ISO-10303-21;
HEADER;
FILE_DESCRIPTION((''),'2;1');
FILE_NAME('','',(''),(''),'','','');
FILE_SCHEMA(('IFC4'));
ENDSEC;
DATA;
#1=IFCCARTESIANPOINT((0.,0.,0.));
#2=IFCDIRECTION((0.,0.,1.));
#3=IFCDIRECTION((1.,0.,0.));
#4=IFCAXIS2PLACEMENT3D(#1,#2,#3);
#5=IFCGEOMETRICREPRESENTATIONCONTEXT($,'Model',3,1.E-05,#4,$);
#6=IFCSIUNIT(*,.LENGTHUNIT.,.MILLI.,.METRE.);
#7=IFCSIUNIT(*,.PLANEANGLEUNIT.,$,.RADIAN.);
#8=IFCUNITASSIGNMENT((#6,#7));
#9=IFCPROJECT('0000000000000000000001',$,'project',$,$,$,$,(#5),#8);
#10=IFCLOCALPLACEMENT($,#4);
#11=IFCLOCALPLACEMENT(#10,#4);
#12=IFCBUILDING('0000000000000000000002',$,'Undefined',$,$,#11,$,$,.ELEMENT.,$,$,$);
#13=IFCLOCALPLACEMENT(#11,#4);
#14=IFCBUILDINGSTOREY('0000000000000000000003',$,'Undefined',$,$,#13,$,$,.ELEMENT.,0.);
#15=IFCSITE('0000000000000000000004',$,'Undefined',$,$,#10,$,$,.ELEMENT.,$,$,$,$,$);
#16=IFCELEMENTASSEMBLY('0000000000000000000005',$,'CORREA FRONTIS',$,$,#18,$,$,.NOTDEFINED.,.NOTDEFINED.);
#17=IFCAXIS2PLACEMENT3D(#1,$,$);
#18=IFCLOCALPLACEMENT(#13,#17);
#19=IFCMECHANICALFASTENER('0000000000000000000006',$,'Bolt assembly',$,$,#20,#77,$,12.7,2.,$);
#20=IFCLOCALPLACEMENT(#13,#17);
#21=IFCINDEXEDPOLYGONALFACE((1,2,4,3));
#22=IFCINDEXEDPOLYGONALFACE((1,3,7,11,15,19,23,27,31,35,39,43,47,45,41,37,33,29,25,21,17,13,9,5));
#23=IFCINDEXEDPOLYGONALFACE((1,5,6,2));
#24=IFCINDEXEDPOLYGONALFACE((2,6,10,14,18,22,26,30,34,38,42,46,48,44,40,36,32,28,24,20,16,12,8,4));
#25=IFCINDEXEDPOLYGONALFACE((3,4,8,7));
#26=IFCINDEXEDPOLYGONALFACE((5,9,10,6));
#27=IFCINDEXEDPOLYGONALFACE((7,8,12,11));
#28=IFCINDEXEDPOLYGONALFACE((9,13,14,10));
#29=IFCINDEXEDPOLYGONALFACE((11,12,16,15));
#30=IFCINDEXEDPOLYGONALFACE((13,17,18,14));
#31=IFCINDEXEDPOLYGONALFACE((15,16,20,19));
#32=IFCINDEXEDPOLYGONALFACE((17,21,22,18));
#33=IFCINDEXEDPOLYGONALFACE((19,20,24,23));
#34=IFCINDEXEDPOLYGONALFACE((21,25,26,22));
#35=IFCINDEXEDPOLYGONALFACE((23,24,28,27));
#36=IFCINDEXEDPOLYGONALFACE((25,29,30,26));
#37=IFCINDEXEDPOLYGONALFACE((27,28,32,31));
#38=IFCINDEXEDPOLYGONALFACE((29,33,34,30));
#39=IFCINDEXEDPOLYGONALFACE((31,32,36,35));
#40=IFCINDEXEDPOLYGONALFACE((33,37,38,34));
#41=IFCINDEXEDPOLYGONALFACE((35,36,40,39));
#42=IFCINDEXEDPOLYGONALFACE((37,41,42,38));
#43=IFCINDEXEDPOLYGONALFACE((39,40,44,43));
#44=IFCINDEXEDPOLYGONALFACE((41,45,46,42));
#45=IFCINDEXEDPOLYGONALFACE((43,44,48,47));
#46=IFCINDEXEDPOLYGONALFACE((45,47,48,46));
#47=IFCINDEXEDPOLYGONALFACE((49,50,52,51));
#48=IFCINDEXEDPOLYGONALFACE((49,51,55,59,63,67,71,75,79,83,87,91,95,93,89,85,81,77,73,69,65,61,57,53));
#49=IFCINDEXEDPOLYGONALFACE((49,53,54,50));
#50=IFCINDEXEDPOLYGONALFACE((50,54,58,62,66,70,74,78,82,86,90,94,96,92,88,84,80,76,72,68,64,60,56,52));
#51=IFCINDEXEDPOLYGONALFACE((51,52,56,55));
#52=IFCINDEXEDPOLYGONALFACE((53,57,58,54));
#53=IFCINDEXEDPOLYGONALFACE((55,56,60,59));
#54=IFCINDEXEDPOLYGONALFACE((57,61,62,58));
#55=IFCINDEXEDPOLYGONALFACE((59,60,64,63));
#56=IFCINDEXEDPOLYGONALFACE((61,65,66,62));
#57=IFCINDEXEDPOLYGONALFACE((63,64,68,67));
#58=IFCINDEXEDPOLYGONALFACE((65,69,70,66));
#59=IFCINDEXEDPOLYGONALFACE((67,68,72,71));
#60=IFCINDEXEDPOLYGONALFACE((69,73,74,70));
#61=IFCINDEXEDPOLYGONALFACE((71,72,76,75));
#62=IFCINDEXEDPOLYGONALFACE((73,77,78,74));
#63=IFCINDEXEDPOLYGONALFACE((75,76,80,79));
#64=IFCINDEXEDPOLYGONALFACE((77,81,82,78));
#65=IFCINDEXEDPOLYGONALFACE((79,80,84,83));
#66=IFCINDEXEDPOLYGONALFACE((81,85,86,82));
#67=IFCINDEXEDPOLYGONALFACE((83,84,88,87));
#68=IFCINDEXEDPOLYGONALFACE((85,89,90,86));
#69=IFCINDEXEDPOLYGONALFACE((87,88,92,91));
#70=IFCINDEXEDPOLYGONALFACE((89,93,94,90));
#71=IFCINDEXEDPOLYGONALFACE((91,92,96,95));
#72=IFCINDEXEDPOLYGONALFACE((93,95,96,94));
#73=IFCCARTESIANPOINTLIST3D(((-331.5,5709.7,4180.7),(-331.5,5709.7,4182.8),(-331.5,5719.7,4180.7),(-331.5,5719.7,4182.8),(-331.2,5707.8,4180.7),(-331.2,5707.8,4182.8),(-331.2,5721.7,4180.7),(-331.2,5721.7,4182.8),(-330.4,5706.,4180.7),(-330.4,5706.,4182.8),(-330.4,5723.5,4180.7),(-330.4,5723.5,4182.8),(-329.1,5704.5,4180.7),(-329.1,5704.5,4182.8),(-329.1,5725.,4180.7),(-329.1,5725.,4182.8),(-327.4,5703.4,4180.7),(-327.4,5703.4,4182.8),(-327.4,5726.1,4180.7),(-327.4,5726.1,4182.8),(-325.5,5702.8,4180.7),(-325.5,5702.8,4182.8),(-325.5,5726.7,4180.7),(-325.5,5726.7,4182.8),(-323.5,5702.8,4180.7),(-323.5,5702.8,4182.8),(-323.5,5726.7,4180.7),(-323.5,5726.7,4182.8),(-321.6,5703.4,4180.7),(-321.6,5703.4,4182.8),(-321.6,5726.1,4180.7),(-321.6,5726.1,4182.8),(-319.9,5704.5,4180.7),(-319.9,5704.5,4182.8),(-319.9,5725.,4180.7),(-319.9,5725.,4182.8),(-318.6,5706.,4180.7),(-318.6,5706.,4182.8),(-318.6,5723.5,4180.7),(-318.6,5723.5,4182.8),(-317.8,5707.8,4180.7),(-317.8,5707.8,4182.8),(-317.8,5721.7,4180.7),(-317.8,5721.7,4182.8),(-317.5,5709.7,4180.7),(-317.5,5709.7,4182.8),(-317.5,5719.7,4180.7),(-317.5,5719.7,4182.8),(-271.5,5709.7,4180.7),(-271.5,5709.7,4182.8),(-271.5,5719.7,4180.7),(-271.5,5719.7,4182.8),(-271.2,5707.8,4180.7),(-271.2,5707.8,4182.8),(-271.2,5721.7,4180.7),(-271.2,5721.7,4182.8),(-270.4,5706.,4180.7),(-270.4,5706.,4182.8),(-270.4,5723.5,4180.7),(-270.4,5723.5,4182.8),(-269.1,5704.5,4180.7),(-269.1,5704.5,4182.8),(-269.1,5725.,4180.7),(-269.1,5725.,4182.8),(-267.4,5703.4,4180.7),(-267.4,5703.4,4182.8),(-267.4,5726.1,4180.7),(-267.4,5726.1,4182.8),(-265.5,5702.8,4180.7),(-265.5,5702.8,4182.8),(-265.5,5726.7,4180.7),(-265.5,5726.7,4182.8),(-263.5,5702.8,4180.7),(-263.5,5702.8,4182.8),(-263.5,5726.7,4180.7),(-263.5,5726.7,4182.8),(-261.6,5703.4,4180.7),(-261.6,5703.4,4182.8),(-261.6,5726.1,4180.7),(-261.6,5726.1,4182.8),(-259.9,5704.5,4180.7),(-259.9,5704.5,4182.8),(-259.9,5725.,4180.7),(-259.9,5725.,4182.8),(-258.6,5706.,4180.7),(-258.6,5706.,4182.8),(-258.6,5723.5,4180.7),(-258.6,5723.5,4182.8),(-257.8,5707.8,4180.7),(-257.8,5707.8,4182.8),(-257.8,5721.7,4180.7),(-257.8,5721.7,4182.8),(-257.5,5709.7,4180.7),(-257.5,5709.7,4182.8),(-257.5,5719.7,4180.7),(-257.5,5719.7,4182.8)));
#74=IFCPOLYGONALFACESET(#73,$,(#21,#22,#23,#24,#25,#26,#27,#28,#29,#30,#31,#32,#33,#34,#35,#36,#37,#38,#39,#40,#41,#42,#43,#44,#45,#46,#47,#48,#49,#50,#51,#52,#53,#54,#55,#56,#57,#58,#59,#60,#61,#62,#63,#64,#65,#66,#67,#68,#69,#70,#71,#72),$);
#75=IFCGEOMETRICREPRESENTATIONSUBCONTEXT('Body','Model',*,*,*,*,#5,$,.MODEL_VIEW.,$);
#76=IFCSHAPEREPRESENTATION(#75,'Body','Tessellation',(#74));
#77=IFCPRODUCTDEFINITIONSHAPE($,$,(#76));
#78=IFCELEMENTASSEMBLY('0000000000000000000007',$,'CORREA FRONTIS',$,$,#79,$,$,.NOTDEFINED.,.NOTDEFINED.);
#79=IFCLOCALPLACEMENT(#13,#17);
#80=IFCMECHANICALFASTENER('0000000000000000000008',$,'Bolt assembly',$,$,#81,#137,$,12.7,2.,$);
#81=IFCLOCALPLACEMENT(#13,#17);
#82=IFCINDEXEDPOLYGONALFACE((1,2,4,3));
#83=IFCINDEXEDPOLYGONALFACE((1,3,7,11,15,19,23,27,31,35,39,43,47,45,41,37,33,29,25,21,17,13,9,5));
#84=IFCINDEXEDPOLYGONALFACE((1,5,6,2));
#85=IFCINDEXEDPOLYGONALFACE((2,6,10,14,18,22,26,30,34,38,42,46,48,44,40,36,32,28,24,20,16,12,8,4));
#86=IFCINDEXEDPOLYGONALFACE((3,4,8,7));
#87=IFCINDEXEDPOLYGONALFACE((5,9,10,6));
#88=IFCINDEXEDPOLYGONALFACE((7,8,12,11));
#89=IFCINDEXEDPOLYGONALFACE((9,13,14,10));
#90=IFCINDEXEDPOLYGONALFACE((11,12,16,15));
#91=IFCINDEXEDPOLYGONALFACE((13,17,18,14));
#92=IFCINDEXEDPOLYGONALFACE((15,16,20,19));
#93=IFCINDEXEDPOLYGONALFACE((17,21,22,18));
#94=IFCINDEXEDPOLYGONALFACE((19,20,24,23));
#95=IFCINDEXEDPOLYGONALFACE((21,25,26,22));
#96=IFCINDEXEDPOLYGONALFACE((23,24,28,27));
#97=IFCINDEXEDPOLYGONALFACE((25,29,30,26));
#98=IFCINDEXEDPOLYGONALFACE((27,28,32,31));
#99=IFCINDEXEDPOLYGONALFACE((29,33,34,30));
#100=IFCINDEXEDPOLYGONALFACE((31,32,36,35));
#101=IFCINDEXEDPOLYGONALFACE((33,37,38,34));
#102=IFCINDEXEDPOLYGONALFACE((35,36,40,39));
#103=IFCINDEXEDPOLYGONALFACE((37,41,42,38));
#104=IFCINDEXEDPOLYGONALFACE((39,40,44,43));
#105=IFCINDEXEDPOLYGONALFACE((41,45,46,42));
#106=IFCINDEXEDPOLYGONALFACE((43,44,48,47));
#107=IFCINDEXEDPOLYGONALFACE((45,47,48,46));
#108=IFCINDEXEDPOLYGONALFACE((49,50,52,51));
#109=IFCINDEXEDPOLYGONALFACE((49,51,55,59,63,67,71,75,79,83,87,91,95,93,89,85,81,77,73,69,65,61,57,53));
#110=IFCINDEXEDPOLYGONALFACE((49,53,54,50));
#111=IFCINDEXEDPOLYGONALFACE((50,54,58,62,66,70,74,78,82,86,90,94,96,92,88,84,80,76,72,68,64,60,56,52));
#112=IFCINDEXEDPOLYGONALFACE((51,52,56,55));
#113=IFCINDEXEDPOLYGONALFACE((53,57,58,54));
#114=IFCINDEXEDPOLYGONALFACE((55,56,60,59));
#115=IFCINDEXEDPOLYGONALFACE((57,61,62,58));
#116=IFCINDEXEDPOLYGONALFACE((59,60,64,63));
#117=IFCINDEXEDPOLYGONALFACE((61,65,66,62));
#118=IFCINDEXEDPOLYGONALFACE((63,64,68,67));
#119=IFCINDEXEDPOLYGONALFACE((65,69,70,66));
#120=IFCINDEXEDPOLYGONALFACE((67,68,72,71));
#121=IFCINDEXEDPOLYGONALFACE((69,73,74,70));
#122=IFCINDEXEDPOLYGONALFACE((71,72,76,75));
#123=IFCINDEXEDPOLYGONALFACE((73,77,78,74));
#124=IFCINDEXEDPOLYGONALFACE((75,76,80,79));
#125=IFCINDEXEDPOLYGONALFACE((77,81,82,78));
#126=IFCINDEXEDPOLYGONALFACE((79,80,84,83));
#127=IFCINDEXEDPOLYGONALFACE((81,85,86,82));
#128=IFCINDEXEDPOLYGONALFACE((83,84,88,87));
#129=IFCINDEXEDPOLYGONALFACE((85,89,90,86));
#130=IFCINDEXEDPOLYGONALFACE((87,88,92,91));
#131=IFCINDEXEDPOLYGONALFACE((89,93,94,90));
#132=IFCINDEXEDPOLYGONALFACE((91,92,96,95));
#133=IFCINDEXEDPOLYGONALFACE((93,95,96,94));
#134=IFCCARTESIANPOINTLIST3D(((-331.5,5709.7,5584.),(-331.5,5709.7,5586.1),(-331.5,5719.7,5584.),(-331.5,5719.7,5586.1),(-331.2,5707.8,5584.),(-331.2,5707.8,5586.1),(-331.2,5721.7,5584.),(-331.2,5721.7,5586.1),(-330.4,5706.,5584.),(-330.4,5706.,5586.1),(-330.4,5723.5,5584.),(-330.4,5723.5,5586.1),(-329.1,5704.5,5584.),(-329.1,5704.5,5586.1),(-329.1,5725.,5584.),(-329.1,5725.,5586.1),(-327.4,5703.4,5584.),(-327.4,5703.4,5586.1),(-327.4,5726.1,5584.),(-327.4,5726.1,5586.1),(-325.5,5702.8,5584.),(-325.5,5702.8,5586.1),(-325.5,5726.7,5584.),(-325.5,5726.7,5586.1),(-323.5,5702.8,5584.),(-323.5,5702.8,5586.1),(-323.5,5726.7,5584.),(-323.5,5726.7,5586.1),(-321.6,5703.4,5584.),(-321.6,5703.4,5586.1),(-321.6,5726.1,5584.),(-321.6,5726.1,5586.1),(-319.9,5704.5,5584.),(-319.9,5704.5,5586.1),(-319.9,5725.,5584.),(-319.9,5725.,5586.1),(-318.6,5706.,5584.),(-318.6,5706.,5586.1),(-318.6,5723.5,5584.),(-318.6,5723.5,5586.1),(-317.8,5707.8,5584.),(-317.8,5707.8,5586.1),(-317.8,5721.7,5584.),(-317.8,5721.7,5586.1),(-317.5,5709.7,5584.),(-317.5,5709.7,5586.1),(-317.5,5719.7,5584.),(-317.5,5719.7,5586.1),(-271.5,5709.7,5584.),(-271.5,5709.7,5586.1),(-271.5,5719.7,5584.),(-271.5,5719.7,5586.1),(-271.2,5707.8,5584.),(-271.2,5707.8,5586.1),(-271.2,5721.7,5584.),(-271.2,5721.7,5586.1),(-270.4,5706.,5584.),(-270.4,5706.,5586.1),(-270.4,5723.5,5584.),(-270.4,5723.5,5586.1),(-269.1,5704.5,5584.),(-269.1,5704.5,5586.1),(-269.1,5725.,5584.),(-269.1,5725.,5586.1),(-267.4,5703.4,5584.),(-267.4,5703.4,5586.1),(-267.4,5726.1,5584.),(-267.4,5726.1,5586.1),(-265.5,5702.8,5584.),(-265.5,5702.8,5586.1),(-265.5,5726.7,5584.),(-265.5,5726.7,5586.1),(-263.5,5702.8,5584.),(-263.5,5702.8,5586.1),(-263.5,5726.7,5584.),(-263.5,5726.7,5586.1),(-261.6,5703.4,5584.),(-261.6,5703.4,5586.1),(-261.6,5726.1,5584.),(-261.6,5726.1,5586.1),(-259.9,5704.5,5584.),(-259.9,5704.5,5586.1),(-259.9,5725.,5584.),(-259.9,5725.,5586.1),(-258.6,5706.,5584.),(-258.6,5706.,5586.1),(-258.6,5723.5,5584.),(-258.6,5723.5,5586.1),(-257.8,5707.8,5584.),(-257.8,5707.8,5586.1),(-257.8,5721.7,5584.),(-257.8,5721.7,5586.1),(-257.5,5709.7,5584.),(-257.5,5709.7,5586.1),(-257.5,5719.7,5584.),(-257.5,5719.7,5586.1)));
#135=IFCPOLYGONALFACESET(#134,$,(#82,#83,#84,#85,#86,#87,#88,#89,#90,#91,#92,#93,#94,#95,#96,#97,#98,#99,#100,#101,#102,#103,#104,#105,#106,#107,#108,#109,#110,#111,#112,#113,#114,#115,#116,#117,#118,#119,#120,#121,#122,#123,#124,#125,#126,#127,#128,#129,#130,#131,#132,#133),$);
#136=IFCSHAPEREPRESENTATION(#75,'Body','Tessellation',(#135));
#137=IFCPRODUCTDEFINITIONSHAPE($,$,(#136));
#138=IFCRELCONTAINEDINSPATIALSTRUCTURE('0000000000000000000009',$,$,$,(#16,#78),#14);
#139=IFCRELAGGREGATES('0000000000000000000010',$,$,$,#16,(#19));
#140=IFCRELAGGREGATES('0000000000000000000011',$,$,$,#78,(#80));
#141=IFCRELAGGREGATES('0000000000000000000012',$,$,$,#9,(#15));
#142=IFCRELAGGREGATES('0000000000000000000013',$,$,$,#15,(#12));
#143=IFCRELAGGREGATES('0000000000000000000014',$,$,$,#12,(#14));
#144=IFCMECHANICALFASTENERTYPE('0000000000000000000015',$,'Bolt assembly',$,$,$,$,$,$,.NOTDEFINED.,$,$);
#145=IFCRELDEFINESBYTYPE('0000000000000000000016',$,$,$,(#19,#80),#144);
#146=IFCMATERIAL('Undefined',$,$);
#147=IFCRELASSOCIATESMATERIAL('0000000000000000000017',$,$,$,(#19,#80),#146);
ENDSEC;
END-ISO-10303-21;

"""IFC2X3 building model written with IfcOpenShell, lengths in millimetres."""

from ifc_helpers import new_model, si_unit, frame, frame_2d, origin_with_axes, place, context, subcontext, project, spatial, polyline, circle_curve, parameter, trimmed, segment, composite_curve, outline, extrude, source, transform, mapped, material, type_object, element, aggregate, save


model = new_model("IFC2X3")

# Units and contexts
model_context = context("Model", 3, precision=1e-05, world=origin_with_axes())
body_context = subcontext(model_context, "Body", "Model", "MODEL_VIEW")
ifc_project = project(units=[si_unit("LENGTHUNIT", "METRE", prefix="MILLI"), si_unit("PLANEANGLEUNIT", "RADIAN")], contexts=[model_context])

# Site, building, storey
site_placement = place(None, origin_with_axes())
site = spatial("IfcSite", under=ifc_project, at=site_placement, Name="Undefined", CompositionType="ELEMENT")
building_placement = place(site_placement, origin_with_axes())
building = spatial("IfcBuilding", under=site, at=building_placement, Name="Undefined", CompositionType="ELEMENT")
storey_placement = place(building_placement, origin_with_axes())
storey = spatial("IfcBuildingStorey", under=building, at=storey_placement, Name="Undefined", CompositionType="ELEMENT", Elevation=0.0)

# Shared definitions
ifc_material_1 = material(Name="Undefined")
mechanical_fastener_type = type_object("IfcMechanicalFastenerType", Name="Bolt assembly")

# Element assembly, mechanical fastener
assembly_1_placement = place(storey_placement, origin_with_axes())
assembly_1 = element("IfcElementAssembly", 1, at=assembly_1_placement, inside=storey, Name="CORREA FRONTIS", AssemblyPlace="NOTDEFINED", PredefinedType="NOTDEFINED")
shared_shape_1 = source(origin_with_axes(), body_context, "Body", "SweptSolid", [
    extrude(outline(composite_curve([segment(polyline([(7.0, 5.0), (7.0, -5.0)]), True, "CONTINUOUS"), segment(trimmed(circle_curve(frame_2d((0.0, -5.0), x_axis=(1.0, 0.0)), 7.0), [parameter(0.0)], [parameter(3.141593)], False, "PARAMETER"), True, "CONTINUOUS"), segment(polyline([(-7.0, -5.0), (-7.0, 5.0)]), True, "CONTINUOUS"), segment(trimmed(circle_curve(frame_2d((0.0, 5.0), x_axis=(-1.0, 0.0)), 7.0), [parameter(0.0)], [parameter(3.141593)], False, "PARAMETER"), True, "DISCONTINUOUS")], self_intersect=False)), frame((0.0, 0.0, 0.0), z_axis=(0.0, 1.0, 0.0), x_axis=(1.0, 0.0, 0.0)), (0.0, 0.0, 1.0), 2.1),
])
mechanical_fastener_1_placement = place(assembly_1_placement, frame((-324.5, 5714.7, 4182.8), z_axis=(0.000001, 1.0, 0.0), x_axis=(1.0, -0.000001, 0.000004)))
mechanical_fastener_1 = element("IfcMechanicalFastener", 2, at=mechanical_fastener_1_placement, type_object=mechanical_fastener_type, material=ifc_material_1, Name="Bolt assembly", NominalDiameter=12.7, NominalLength=2.0, context=body_context, shape_type="MappedRepresentation", body=[
    mapped(shared_shape_1, transform((0.0, 0.0, 0.0))),
    mapped(shared_shape_1, transform((60.0, 0.0, 0.0))),
])

# Element assembly, mechanical fastener
assembly_2_placement = place(storey_placement, origin_with_axes())
assembly_2 = element("IfcElementAssembly", 3, at=assembly_2_placement, inside=storey, Name="CORREA FRONTIS", AssemblyPlace="NOTDEFINED", PredefinedType="NOTDEFINED")
shared_shape_2 = source(origin_with_axes(), body_context, "Body", "SweptSolid", [
    extrude(outline(composite_curve([segment(polyline([(7.0, 5.0), (7.0, -5.0)]), True, "CONTINUOUS"), segment(trimmed(circle_curve(frame_2d((0.0, -5.0), x_axis=(1.0, 0.0)), 7.0), [parameter(0.0)], [parameter(3.141593)], False, "PARAMETER"), True, "CONTINUOUS"), segment(polyline([(-7.0, -5.0), (-7.0, 5.0)]), True, "CONTINUOUS"), segment(trimmed(circle_curve(frame_2d((0.0, 5.0), x_axis=(-1.0, 0.0)), 7.0), [parameter(0.0)], [parameter(3.141593)], False, "PARAMETER"), True, "DISCONTINUOUS")], self_intersect=False)), frame((0.0, 0.0, 0.0), z_axis=(0.0, 1.0, 0.0), x_axis=(1.0, 0.0, 0.0)), (0.0, 0.0, 1.0), 2.1),
])
mechanical_fastener_2_placement = place(assembly_2_placement, frame((-324.5, 5714.7, 5586.1), z_axis=(0.000001, 1.0, 0.0), x_axis=(1.0, -0.000001, 0.000004)))
mechanical_fastener_2 = element("IfcMechanicalFastener", 4, at=mechanical_fastener_2_placement, type_object=mechanical_fastener_type, material=ifc_material_1, Name="Bolt assembly", NominalDiameter=12.7, NominalLength=2.0, context=body_context, shape_type="MappedRepresentation", body=[
    mapped(shared_shape_2, transform((0.0, 0.0, 0.0))),
    mapped(shared_shape_2, transform((60.0, 0.0, 0.0))),
])

aggregate(assembly_1, [mechanical_fastener_1])
aggregate(assembly_2, [mechanical_fastener_2])

save(model, "model.ifc")
